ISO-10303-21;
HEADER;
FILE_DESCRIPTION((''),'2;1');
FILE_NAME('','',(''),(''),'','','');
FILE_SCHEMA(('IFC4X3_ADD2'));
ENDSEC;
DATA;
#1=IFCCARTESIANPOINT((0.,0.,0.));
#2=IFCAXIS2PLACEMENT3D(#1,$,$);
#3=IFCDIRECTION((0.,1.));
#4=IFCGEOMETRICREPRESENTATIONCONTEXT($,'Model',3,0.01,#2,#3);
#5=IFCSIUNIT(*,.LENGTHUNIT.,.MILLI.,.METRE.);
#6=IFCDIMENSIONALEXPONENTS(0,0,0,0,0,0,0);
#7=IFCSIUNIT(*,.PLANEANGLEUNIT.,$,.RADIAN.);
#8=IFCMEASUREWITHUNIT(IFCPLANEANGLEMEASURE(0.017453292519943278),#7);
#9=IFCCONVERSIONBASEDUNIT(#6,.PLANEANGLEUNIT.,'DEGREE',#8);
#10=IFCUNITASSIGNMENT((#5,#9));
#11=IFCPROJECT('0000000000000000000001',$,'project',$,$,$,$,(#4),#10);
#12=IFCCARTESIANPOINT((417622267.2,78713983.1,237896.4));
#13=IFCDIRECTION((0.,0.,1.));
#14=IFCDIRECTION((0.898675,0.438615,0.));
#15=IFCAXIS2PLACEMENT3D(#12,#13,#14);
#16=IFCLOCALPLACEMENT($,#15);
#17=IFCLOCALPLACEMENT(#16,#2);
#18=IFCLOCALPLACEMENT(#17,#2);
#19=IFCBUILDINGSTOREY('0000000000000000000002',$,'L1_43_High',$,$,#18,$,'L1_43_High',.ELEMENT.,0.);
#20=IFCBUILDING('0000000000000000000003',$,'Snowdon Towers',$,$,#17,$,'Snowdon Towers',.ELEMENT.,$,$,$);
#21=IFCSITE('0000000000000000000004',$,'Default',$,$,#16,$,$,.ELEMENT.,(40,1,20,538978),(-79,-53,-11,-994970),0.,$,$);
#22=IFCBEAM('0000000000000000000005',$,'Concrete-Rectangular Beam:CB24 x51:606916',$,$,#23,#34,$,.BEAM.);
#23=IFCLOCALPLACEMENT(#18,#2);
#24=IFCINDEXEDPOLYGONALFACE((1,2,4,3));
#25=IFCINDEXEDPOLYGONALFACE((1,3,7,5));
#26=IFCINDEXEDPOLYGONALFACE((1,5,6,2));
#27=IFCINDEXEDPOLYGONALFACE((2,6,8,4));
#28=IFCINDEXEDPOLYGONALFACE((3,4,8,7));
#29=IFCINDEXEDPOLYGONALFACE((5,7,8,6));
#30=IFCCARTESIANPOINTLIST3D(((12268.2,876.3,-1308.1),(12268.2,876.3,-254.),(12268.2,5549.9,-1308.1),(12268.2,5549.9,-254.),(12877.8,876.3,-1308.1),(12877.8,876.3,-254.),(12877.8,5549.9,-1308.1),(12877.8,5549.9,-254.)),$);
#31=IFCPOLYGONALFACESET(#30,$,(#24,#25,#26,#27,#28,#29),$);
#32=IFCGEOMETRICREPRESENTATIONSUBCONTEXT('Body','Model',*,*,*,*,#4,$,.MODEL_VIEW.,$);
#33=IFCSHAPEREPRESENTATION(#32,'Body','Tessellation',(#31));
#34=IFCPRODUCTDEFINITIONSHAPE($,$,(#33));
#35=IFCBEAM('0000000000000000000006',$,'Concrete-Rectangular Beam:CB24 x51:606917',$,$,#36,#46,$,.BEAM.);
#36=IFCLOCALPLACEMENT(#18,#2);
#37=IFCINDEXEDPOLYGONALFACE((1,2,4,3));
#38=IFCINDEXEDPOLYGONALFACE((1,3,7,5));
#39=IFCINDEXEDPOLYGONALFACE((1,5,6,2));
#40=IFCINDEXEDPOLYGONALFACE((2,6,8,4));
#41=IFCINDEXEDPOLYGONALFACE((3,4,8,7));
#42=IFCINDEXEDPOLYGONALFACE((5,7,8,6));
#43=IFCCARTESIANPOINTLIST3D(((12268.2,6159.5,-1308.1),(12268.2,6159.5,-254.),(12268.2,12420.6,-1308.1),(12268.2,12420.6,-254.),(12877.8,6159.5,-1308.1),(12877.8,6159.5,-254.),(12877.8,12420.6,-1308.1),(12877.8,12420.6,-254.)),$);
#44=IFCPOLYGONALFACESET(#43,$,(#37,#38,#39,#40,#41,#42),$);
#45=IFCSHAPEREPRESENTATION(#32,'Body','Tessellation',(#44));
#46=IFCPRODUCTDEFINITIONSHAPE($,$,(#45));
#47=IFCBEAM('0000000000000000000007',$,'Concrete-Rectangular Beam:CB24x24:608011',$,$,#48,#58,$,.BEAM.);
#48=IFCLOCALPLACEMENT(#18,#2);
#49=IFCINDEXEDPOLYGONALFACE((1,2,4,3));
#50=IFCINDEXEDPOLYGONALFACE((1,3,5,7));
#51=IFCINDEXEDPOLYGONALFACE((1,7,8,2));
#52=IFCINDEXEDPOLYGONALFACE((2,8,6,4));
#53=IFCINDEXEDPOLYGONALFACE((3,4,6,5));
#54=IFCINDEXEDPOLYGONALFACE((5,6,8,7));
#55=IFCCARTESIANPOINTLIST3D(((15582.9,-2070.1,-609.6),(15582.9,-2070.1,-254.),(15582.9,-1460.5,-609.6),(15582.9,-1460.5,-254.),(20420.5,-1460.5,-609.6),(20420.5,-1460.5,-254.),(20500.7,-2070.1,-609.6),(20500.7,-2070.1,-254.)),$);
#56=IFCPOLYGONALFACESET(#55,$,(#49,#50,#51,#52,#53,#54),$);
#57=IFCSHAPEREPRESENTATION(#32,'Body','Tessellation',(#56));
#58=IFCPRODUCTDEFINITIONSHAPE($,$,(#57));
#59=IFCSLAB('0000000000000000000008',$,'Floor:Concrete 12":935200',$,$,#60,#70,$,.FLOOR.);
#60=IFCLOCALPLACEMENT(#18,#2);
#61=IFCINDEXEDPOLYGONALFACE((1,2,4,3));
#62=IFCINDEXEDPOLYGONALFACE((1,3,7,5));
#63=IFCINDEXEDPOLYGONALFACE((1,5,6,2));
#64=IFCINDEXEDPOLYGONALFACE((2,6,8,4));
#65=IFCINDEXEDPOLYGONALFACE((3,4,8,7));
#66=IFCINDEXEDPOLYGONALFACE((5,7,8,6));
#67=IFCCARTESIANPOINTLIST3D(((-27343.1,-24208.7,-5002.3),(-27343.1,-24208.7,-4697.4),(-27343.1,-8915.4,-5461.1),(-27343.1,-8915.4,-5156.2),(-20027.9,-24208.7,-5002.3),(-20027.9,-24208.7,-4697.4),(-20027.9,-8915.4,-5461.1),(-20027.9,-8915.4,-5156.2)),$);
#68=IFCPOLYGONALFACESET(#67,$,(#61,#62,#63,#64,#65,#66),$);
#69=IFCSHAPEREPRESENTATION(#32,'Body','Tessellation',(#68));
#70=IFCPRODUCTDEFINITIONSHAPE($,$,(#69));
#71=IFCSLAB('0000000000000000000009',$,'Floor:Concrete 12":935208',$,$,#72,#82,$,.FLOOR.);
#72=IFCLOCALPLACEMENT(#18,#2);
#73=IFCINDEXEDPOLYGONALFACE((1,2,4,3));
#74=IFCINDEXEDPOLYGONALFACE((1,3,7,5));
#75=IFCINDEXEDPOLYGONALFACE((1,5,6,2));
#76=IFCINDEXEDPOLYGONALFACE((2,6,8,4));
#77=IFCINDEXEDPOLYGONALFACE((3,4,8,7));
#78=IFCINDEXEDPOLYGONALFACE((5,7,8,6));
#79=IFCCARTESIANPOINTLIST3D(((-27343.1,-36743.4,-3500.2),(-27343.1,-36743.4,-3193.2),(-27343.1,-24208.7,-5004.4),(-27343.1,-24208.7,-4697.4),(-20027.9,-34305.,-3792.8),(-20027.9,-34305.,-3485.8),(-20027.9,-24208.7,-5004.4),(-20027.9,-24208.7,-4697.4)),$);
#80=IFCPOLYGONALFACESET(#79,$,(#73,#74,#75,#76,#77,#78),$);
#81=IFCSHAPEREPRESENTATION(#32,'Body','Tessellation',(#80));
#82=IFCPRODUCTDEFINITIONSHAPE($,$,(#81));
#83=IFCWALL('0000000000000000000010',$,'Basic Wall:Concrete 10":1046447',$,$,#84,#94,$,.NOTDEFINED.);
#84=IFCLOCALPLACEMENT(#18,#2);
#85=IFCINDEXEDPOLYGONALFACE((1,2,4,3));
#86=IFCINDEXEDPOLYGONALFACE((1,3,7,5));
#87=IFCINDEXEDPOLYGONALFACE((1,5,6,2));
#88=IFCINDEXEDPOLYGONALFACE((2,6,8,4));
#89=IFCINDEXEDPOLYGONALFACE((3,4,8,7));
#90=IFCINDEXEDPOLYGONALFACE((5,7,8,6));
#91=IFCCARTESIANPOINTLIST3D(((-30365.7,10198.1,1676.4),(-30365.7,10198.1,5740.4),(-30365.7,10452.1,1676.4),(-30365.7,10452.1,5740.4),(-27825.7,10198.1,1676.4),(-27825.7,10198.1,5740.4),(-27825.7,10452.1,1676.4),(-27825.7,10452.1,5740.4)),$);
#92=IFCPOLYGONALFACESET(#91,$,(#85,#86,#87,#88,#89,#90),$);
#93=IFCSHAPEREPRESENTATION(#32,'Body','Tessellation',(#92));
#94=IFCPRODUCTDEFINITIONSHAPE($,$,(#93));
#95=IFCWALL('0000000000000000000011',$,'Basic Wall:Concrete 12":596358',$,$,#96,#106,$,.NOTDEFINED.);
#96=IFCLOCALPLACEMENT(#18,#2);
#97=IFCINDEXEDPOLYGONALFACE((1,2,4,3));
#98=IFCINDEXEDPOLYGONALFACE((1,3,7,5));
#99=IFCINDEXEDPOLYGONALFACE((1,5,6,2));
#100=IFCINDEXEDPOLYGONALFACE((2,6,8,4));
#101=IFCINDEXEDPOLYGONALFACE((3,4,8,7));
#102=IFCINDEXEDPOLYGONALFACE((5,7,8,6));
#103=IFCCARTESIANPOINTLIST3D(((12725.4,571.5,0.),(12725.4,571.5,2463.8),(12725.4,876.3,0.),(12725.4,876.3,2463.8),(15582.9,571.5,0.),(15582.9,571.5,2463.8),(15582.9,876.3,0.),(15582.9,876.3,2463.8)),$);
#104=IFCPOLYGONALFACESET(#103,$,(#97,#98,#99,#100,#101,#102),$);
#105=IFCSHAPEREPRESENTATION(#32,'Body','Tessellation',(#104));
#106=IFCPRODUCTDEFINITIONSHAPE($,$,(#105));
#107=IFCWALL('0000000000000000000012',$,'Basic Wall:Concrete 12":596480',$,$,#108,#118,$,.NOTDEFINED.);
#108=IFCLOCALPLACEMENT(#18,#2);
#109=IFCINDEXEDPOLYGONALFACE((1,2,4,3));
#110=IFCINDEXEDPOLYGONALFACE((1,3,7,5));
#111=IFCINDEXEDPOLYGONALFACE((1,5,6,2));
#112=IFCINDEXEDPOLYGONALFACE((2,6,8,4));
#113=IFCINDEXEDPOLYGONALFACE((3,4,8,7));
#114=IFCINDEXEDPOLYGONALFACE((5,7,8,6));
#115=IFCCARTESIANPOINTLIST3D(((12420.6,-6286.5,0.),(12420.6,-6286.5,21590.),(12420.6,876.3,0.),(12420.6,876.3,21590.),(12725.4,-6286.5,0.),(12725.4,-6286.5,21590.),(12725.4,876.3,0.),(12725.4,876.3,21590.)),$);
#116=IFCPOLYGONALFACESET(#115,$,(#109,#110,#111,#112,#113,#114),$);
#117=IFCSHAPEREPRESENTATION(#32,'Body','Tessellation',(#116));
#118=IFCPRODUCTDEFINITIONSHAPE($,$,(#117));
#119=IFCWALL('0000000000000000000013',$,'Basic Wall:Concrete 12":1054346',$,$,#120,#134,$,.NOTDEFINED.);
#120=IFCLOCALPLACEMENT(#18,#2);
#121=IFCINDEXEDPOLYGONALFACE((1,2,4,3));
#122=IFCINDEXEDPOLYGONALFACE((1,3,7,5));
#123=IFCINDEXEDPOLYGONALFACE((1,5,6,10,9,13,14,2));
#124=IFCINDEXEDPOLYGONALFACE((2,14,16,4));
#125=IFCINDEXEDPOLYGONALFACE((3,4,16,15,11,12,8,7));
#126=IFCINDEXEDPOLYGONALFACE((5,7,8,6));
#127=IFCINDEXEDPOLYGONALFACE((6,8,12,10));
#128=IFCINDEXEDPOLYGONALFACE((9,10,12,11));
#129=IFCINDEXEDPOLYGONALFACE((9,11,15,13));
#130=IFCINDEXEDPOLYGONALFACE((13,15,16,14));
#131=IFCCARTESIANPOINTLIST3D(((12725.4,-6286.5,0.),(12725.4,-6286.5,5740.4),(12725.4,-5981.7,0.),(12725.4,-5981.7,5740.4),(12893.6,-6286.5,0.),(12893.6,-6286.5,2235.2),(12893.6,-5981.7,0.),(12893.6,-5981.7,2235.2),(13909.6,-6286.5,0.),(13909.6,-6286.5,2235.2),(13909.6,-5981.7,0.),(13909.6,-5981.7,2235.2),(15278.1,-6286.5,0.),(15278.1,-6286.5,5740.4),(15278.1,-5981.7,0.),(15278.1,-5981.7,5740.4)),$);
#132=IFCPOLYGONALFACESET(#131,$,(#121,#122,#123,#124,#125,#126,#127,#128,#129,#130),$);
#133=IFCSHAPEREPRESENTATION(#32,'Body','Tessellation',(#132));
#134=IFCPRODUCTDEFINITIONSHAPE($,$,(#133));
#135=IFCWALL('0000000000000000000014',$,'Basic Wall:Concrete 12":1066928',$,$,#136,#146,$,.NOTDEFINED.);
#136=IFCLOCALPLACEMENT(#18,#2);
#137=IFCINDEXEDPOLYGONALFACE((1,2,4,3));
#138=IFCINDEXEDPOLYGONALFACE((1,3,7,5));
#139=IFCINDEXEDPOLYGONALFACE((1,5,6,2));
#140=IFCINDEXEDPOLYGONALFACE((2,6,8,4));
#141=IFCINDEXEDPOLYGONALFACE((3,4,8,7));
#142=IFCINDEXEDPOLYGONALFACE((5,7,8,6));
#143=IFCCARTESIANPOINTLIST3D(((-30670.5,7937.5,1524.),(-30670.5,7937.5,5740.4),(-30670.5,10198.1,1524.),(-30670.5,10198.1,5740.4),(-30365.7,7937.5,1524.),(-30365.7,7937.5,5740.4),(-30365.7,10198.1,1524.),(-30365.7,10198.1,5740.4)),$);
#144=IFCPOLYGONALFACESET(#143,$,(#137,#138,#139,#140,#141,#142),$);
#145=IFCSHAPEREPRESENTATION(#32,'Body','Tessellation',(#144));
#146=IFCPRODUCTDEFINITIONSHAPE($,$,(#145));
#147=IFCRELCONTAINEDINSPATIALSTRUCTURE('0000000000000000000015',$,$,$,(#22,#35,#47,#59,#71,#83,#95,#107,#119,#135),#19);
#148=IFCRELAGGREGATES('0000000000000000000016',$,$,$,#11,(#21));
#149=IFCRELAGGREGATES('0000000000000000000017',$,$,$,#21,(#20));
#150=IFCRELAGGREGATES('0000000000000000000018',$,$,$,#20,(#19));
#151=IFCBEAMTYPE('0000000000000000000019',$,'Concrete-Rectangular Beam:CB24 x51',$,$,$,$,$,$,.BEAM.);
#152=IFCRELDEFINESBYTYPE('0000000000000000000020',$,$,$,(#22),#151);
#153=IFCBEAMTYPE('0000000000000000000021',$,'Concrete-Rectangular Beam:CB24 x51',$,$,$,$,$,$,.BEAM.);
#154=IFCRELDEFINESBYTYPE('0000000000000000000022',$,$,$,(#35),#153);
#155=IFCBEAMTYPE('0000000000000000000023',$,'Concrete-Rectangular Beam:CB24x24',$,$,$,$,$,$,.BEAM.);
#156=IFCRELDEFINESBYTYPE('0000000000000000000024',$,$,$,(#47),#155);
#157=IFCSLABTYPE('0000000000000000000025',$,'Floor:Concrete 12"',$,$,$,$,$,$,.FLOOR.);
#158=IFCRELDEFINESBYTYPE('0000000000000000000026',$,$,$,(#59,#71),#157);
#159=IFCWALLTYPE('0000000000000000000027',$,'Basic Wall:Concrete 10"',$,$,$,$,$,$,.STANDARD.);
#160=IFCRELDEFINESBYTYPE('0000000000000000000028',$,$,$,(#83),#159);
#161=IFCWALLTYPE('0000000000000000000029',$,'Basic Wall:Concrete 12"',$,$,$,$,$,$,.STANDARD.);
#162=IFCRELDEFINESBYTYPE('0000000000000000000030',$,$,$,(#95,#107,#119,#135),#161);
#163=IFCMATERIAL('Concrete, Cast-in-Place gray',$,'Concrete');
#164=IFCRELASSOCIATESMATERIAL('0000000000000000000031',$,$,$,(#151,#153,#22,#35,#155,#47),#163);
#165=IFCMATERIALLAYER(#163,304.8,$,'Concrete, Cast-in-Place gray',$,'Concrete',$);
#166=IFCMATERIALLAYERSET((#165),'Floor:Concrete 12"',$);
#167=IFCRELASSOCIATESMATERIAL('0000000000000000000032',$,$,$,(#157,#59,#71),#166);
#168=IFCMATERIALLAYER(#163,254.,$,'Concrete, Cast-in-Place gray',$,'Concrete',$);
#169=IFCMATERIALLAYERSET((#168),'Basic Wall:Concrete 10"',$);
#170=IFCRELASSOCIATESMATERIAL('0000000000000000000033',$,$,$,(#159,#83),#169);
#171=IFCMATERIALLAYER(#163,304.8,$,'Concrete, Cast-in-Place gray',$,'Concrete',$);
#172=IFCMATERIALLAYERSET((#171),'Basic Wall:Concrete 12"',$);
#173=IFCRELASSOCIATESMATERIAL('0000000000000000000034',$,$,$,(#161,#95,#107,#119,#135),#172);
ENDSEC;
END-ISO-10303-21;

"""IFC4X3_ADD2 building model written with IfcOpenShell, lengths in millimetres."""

from ifc_helpers import new_model, entity, si_unit, converted_unit, direction, frame, frame_2d, origin, place, context, subcontext, project, spatial, polyline, rectangle, outline, extrude, clip, halfspace, source, transform, mapped, material, layer, layer_set, layer_usage, material_profile, profile_set, profile_usage, type_object, type_shapes, element, save


model = new_model("IFC4X3_ADD2")

# Units and contexts
model_context = context("Model", 3, precision=0.01, world=origin(), true_north=direction((0.0, 1.0)))
body_context = subcontext(model_context, "Body", "Model", "MODEL_VIEW")
ifc_project = project(units=[si_unit("LENGTHUNIT", "METRE", prefix="MILLI"), converted_unit("PLANEANGLEUNIT", "DEGREE", entity("IfcPlaneAngleMeasure", 0.017453292519943278), si_unit("PLANEANGLEUNIT", "RADIAN"), dimensions=[0, 0, 0, 0, 0, 0, 0])], contexts=[model_context])

# Site, building, storey
site_placement = place(None, frame((417622267.2, 78713983.1, 237896.4), z_axis=(0.0, 0.0, 1.0), x_axis=(0.898675, 0.438615, 0.0)))
site = spatial("IfcSite", under=ifc_project, at=site_placement, Name="Default", CompositionType="ELEMENT", RefLatitude=(40, 1, 20, 538978), RefLongitude=(-79, -53, -11, -994970), RefElevation=0.0)
building_placement = place(site_placement, origin())
building = spatial("IfcBuilding", under=site, at=building_placement, Name="Snowdon Towers", LongName="Snowdon Towers", CompositionType="ELEMENT")
storey_placement = place(building_placement, origin())
storey = spatial("IfcBuildingStorey", under=building, at=storey_placement, Name="L1_43_High", LongName="L1_43_High", CompositionType="ELEMENT", Elevation=0.0)

# Beams
ifc_material_1 = material(Name="Concrete, Cast-in-Place gray", Category="Concrete")
ifc_material_profile_1 = material_profile(ifc_material_1, rectangle(XDim=355.6, YDim=609.6, at=frame_2d((0.0, 0.0), x_axis=(1.0, 0.0))), Name="CB24x24")
ifc_profile_set_1 = profile_set([ifc_material_profile_1], Name="CB24x24")
ifc_profile_usage_1 = profile_usage(ifc_profile_set_1, cardinal=8)
ifc_material_profile_2 = material_profile(ifc_material_1, rectangle(XDim=1054.1, YDim=609.6, at=frame_2d((0.0, 0.0), x_axis=(0.0, 1.0))), Name="CB24 x51")
ifc_profile_set_2 = profile_set([ifc_material_profile_2], Name="CB24 x51")
ifc_profile_usage_2 = profile_usage(ifc_profile_set_2, cardinal=8)
beam_type_1 = type_object("IfcBeamType", Name="Concrete-Rectangular Beam:CB24 x51", PredefinedType="BEAM", material=ifc_profile_set_2)
shared_shape_1 = source(origin(), body_context, "Body", "SweptSolid", [
    extrude(rectangle(XDim=1054.1, YDim=609.6, at=frame_2d((0.0, 0.0), x_axis=(0.0, 1.0))), frame((12573.0, 876.3, -781.0), z_axis=(0.0, 1.0, 0.0), x_axis=(-1.0, 0.0, 0.0)), (0.0, 0.0, 1.0), 4673.6),
])
type_shapes(beam_type_1, [shared_shape_1])
beam_1_placement = place(storey_placement, origin())
element("IfcBeam", 1, at=beam_1_placement, inside=storey, type_object=beam_type_1, material=ifc_profile_usage_2, Name="Concrete-Rectangular Beam:CB24 x51:606916", PredefinedType="BEAM", context=body_context, shape_type="MappedRepresentation", body=[
    mapped(shared_shape_1, transform((0.0, 0.0, 0.0), scale=1.0)),
])
beam_type_2 = type_object("IfcBeamType", Name="Concrete-Rectangular Beam:CB24 x51", PredefinedType="BEAM", material=ifc_profile_set_2)
shared_shape_2 = source(origin(), body_context, "Body", "SweptSolid", [
    extrude(rectangle(XDim=1054.1, YDim=609.6, at=frame_2d((0.0, 0.0), x_axis=(0.0, 1.0))), frame((12573.0, 6159.5, -781.0), z_axis=(0.0, 1.0, 0.0), x_axis=(-1.0, 0.0, 0.0)), (0.0, 0.0, 1.0), 6261.1),
])
type_shapes(beam_type_2, [shared_shape_2])
beam_2_placement = place(storey_placement, origin())
element("IfcBeam", 2, at=beam_2_placement, inside=storey, type_object=beam_type_2, material=ifc_profile_usage_2, Name="Concrete-Rectangular Beam:CB24 x51:606917", PredefinedType="BEAM", context=body_context, shape_type="MappedRepresentation", body=[
    mapped(shared_shape_2, transform((0.0, 0.0, 0.0), scale=1.0)),
])
beam_type_3 = type_object("IfcBeamType", Name="Concrete-Rectangular Beam:CB24x24", PredefinedType="BEAM", material=ifc_profile_set_1)
shared_shape_3 = source(origin(), body_context, "Body", "Clipping", [
    clip(extrude(rectangle(XDim=355.6, YDim=609.6, at=frame_2d((0.0, 0.0), x_axis=(1.0, 0.0))), frame((15582.9, -1765.3, -431.8), z_axis=(1.0, 0.0, 0.0), x_axis=(0.0, 0.0, -1.0)), (0.0, 0.0, 1.0), 4917.8), halfspace(frame((18529.5, 12902.8, -5334.0), z_axis=(0.991445, 0.130526, 0.0), x_axis=(0.130526, -0.991445, 0.0)), False)),
])
type_shapes(beam_type_3, [shared_shape_3])
beam_3_placement = place(storey_placement, origin())
element("IfcBeam", 3, at=beam_3_placement, inside=storey, type_object=beam_type_3, material=ifc_profile_usage_1, Name="Concrete-Rectangular Beam:CB24x24:608011", PredefinedType="BEAM", context=body_context, shape_type="MappedRepresentation", body=[
    mapped(shared_shape_3, transform((0.0, 0.0, 0.0), scale=1.0)),
])

# Slabs
ifc_layer_1 = layer(ifc_material_1, 304.8, Name="Concrete, Cast-in-Place gray", Category="Concrete")
ifc_layer_set_1 = layer_set([ifc_layer_1], Name="Floor:Concrete 12\"")
ifc_layer_usage_1 = layer_usage(ifc_layer_set_1, "AXIS3", "POSITIVE", 0.0)
slab_type_1 = type_object("IfcSlabType", Name="Floor:Concrete 12\"", PredefinedType="FLOOR", material=ifc_layer_set_1)
slab_1_placement = place(storey_placement, origin())
element("IfcSlab", 4, at=slab_1_placement, inside=storey, type_object=slab_type_1, material=ifc_layer_usage_1, Name="Floor:Concrete 12\":935200", PredefinedType="FLOOR", context=body_context, shape_type="Clipping", body=[
    clip(clip(extrude(rectangle(XDim=15300.2, YDim=7315.2, at=frame_2d((0.0, 0.0), x_axis=(1.0, 0.0))), frame((-23685.5, -16562.1, -4926.8), z_axis=(0.0, -0.029987, -0.99955), x_axis=(0.0, 0.99955, -0.029987)), (0.029987, 0.0, 0.99955), 305.1), halfspace(frame((-23685.5, -8915.4, -5461.1), z_axis=(0.0, -0.029987, -0.99955), x_axis=(0.0, -0.99955, 0.029987)), False)), halfspace(frame((-23685.5, -8915.4, -5156.2), z_axis=(0.0, 0.029987, 0.99955), x_axis=(0.0, 0.99955, -0.029987)), False)),
])
ifc_layer_usage_2 = layer_usage(ifc_layer_set_1, "AXIS3", "POSITIVE", 0.0)
slab_2_placement = place(storey_placement, origin())
element("IfcSlab", 5, at=slab_2_placement, inside=storey, type_object=slab_type_1, material=ifc_layer_usage_2, Name="Floor:Concrete 12\":935208", PredefinedType="FLOOR", context=body_context, shape_type="Clipping", body=[
    clip(clip(extrude(outline(polyline([(-6926.3, -3657.6), (5698.3, -3657.6), (5698.3, 3657.6), (-4470.4, 3657.6), (-6926.3, -3657.6)])), frame((-23685.5, -29866.5, -4018.5), z_axis=(0.0, -0.119145, -0.992877), x_axis=(0.0, 0.992877, -0.119145)), (0.119145, 0.0, 0.992877), 309.2), halfspace(frame((-23685.5, -24208.7, -5004.4), z_axis=(0.0, -0.119145, -0.992877), x_axis=(0.0, -0.992877, 0.119145)), False)), halfspace(frame((-23685.5, -24208.7, -4697.4), z_axis=(0.0, 0.119145, 0.992877), x_axis=(0.0, 0.992877, -0.119145)), False)),
])

# Walls
ifc_layer_2 = layer(ifc_material_1, 254.0, Name="Concrete, Cast-in-Place gray", Category="Concrete")
ifc_layer_set_2 = layer_set([ifc_layer_2], Name="Basic Wall:Concrete 10\"")
wall_type_1 = type_object("IfcWallType", Name="Basic Wall:Concrete 10\"", PredefinedType="STANDARD", material=ifc_layer_set_2)
wall_1_placement = place(storey_placement, frame((-30365.7, 10325.1, 1676.4)))
element("IfcWall", 6, at=wall_1_placement, inside=storey, type_object=wall_type_1, material=ifc_layer_set_2, Name="Basic Wall:Concrete 10\":1046447", PredefinedType="NOTDEFINED", context=body_context, shape_type="SweptSolid", body=[
    extrude(rectangle(XDim=2540.0, YDim=254.0, at=frame_2d((1270.0, 0.0), x_axis=(-1.0, 0.0))), origin(), (0.0, 0.0, 1.0), 4064.0),
])
ifc_layer_3 = layer(ifc_material_1, 304.8, Name="Concrete, Cast-in-Place gray", Category="Concrete")
ifc_layer_set_3 = layer_set([ifc_layer_3], Name="Basic Wall:Concrete 12\"")
wall_type_2 = type_object("IfcWallType", Name="Basic Wall:Concrete 12\"", PredefinedType="STANDARD", material=ifc_layer_set_3)
wall_2_placement = place(storey_placement, frame((15582.9, 723.9, 0.0), z_axis=(0.0, 0.0, 1.0), x_axis=(-1.0, 0.0, 0.0)))
element("IfcWall", 7, at=wall_2_placement, inside=storey, type_object=wall_type_2, material=ifc_layer_set_3, Name="Basic Wall:Concrete 12\":596358", PredefinedType="NOTDEFINED", context=body_context, shape_type="SweptSolid", body=[
    extrude(rectangle(XDim=2857.5, YDim=304.8, at=frame_2d((1428.8, 0.0), x_axis=(-1.0, 0.0))), origin(), (0.0, 0.0, 1.0), 2463.8),
])
wall_3_placement = place(storey_placement, frame((12573.0, 876.3, 0.0), z_axis=(0.0, 0.0, 1.0), x_axis=(0.0, -1.0, 0.0)))
element("IfcWall", 8, at=wall_3_placement, inside=storey, type_object=wall_type_2, material=ifc_layer_set_3, Name="Basic Wall:Concrete 12\":596480", PredefinedType="NOTDEFINED", context=body_context, shape_type="SweptSolid", body=[
    extrude(rectangle(XDim=7162.8, YDim=304.8, at=frame_2d((3581.4, 0.0), x_axis=(-1.0, 0.0))), origin(), (0.0, 0.0, 1.0), 21590.0),
])

# Wall, opening
wall_4_placement = place(storey_placement, frame((15278.1, -6134.1, 0.0), z_axis=(0.0, 0.0, 1.0), x_axis=(-1.0, 0.0, 0.0)))
wall_4 = element("IfcWall", 9, at=wall_4_placement, inside=storey, type_object=wall_type_2, material=ifc_layer_set_3, Name="Basic Wall:Concrete 12\":1054346", PredefinedType="NOTDEFINED", context=body_context, shape_type="SweptSolid", body=[
    extrude(rectangle(XDim=2552.7, YDim=304.8, at=frame_2d((1276.3, 0.0), x_axis=(-1.0, 0.0))), origin(), (0.0, 0.0, 1.0), 5740.4),
])
opening_placement = place(wall_4_placement, origin())
element("IfcOpeningElement", 10, at=opening_placement, cuts=wall_4, PredefinedType="OPENING", context=body_context, shape_type="SweptSolid", body=[
    extrude(rectangle(XDim=2235.2, YDim=1016.0, at=frame_2d((0.0, 0.0), x_axis=(0.0, 1.0))), frame((1876.5, 152.4, 1117.6), z_axis=(0.0, -1.0, 0.0), x_axis=(1.0, 0.0, 0.0)), (0.0, 0.0, 1.0), 304.8),
])

# Wall
wall_5_placement = place(storey_placement, frame((-30518.1, 7937.5, 1524.0), z_axis=(0.0, 0.0, 1.0), x_axis=(0.0, 1.0, 0.0)))
element("IfcWall", 11, at=wall_5_placement, inside=storey, type_object=wall_type_2, material=ifc_layer_set_3, Name="Basic Wall:Concrete 12\":1066928", PredefinedType="NOTDEFINED", context=body_context, shape_type="SweptSolid", body=[
    extrude(rectangle(XDim=2260.6, YDim=304.8, at=frame_2d((1130.3, 0.0), x_axis=(-1.0, 0.0))), origin(), (0.0, 0.0, 1.0), 4216.4),
])

save(model, "model.ifc")
